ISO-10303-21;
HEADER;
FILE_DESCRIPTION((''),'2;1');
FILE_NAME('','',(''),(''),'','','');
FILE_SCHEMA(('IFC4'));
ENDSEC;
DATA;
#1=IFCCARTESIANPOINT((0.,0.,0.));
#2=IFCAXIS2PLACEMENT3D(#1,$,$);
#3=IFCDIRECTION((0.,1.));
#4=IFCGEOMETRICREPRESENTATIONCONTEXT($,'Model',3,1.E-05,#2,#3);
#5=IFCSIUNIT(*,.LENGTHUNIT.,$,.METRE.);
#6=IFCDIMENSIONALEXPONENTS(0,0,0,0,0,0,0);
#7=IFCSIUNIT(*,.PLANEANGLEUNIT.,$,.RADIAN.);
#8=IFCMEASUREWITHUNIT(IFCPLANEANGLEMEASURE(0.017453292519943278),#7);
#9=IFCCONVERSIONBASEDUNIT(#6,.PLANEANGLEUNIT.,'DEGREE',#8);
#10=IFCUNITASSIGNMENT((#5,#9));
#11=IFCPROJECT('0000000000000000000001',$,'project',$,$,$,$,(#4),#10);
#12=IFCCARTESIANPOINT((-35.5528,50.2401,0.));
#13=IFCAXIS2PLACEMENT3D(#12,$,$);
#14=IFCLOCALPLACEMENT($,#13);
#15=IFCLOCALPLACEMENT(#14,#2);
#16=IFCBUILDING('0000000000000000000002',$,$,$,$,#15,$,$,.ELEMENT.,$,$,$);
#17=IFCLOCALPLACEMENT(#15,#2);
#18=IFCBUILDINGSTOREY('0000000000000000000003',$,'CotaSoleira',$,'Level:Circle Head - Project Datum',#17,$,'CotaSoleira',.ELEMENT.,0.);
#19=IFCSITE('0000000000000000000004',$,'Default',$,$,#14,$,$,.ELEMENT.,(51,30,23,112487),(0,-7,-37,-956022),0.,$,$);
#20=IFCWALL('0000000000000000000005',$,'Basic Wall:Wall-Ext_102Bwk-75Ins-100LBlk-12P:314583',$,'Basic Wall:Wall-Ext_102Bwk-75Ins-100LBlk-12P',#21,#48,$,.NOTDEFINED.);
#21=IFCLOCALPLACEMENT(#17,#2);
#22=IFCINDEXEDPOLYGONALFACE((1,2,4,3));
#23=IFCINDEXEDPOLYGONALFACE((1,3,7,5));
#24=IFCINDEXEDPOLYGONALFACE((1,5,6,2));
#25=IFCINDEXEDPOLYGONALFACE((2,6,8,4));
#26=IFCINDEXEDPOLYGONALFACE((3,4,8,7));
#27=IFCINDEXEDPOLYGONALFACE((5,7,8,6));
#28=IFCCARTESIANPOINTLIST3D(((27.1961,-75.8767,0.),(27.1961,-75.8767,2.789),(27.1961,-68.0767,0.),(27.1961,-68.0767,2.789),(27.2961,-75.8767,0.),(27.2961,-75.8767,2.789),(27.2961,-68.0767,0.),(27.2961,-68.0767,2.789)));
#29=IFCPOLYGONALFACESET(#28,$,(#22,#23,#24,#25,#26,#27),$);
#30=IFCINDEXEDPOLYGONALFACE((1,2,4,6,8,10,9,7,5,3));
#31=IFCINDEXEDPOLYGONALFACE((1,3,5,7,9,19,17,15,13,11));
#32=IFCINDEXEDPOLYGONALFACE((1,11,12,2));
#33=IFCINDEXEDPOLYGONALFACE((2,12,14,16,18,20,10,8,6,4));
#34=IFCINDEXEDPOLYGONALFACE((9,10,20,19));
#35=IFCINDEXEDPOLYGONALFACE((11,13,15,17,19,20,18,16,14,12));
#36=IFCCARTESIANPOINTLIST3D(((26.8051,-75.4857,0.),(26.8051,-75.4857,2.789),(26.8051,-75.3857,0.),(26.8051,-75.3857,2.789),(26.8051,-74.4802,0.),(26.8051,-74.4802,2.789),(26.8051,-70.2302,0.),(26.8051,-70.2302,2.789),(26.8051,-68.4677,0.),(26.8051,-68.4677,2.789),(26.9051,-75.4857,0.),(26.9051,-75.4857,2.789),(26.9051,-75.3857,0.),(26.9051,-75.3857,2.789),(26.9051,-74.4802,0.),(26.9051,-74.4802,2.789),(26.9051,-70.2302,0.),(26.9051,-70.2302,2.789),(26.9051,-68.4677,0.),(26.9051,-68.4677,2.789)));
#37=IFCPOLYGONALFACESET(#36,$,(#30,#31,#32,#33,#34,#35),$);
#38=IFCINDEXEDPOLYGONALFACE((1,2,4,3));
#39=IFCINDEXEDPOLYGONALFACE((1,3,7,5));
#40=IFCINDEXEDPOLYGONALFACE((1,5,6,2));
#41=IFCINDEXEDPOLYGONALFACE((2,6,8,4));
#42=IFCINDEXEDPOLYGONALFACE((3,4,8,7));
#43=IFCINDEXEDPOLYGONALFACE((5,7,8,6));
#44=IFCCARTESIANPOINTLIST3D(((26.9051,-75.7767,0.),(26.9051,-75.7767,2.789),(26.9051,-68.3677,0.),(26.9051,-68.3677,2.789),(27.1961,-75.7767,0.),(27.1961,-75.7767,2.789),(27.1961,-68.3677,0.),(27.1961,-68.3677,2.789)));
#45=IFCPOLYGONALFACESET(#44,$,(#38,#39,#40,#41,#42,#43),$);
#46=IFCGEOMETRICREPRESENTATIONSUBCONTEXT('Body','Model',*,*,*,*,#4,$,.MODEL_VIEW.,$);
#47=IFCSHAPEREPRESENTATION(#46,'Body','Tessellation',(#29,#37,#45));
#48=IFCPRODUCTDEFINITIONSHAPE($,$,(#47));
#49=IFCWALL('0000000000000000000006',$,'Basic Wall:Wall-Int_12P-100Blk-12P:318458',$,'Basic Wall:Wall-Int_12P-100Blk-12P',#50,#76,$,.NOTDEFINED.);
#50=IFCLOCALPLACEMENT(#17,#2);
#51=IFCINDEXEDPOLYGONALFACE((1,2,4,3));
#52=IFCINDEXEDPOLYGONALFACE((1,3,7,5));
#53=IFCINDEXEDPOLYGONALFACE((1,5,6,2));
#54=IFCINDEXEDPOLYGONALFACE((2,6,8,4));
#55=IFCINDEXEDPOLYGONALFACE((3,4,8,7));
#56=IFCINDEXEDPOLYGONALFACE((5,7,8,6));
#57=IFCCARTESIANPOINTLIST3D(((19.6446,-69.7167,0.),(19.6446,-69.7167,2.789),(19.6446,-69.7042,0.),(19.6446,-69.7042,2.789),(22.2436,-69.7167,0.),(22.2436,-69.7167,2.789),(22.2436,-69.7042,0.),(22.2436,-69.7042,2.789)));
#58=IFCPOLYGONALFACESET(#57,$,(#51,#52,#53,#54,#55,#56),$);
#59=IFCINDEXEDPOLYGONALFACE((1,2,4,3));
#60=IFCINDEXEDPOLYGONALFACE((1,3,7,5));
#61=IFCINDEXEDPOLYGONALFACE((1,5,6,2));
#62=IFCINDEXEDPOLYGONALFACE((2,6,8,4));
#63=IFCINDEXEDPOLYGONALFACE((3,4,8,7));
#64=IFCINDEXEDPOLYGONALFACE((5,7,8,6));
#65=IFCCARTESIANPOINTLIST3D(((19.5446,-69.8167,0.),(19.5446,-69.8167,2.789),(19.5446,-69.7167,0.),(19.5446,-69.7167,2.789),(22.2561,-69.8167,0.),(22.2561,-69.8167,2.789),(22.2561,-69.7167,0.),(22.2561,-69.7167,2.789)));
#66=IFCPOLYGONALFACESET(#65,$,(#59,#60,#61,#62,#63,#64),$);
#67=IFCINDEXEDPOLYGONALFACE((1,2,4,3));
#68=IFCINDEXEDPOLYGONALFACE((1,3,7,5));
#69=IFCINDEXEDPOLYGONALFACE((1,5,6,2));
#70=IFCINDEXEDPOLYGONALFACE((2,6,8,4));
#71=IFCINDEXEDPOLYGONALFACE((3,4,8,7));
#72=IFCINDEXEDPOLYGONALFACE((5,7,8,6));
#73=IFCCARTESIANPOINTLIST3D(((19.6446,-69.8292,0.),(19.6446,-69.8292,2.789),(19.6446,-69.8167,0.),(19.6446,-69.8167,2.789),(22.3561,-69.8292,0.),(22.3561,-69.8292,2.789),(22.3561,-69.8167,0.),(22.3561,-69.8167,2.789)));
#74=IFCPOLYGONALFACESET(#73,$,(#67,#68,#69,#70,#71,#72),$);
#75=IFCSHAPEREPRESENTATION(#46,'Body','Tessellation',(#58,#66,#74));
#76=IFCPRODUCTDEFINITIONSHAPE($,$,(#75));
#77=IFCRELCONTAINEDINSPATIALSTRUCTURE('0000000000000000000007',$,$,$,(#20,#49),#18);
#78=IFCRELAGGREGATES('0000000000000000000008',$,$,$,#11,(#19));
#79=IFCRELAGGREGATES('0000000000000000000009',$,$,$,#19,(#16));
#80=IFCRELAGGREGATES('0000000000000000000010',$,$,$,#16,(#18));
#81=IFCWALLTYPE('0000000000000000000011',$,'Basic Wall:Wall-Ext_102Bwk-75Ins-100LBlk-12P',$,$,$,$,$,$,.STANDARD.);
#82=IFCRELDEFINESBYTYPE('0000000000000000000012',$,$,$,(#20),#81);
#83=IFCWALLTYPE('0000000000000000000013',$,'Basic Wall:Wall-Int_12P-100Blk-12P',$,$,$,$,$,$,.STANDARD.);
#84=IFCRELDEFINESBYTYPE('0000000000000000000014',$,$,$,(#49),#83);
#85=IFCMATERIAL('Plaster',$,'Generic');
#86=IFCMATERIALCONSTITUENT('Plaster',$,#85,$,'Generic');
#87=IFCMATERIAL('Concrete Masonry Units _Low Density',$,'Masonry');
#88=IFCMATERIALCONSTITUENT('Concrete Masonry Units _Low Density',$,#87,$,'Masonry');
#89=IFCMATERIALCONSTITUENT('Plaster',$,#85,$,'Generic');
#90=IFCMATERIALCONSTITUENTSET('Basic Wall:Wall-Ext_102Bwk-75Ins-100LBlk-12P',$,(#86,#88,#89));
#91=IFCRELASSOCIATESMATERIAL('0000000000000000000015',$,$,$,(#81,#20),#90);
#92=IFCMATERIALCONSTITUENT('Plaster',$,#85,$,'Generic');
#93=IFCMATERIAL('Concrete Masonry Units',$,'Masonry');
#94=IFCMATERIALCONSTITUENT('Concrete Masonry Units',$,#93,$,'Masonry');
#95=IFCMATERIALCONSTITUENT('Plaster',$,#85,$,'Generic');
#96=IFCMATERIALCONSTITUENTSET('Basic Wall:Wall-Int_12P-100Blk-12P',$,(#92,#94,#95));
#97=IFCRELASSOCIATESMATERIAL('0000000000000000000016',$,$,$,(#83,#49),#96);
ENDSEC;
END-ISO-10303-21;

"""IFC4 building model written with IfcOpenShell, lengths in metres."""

from ifc_helpers import new_model, entity, si_unit, converted_unit, direction, frame, origin, place, context, subcontext, project, spatial, indexed_curve, outline, extrude, material, constituent, constituent_set, type_object, element, save


model = new_model("IFC4")

# Units and contexts
model_context = context("Model", 3, precision=1e-05, world=origin(), true_north=direction((0.0, 1.0)))
body_context = subcontext(model_context, "Body", "Model", "MODEL_VIEW")
ifc_project = project(units=[si_unit("LENGTHUNIT", "METRE"), converted_unit("PLANEANGLEUNIT", "DEGREE", entity("IfcPlaneAngleMeasure", 0.017453292519943278), si_unit("PLANEANGLEUNIT", "RADIAN"), dimensions=[0, 0, 0, 0, 0, 0, 0])], contexts=[model_context])

# Site, building, storey
site_placement = place(None, frame((-35.5528, 50.2401, 0.0)))
site = spatial("IfcSite", under=ifc_project, at=site_placement, Name="Default", CompositionType="ELEMENT", RefLatitude=(51, 30, 23, 112487), RefLongitude=(0, -7, -37, -956022), RefElevation=0.0)
building_placement = place(site_placement, origin())
building = spatial("IfcBuilding", under=site, at=building_placement, CompositionType="ELEMENT")
storey_placement = place(building_placement, origin())
storey = spatial("IfcBuildingStorey", under=building, at=storey_placement, Name="CotaSoleira", ObjectType="Level:Circle Head - Project Datum", LongName="CotaSoleira", CompositionType="ELEMENT", Elevation=0.0)

# Wall
ifc_material_1 = material(Name="Plaster", Category="Generic")
ifc_constituent_1 = constituent(ifc_material_1, Name="Plaster", Category="Generic")
ifc_material_2 = material(Name="Concrete Masonry Units _Low Density", Category="Masonry")
ifc_constituent_2 = constituent(ifc_material_2, Name="Concrete Masonry Units _Low Density", Category="Masonry")
ifc_constituent_3 = constituent(ifc_material_1, Name="Plaster", Category="Generic")
ifc_constituent_set_1 = constituent_set(constituents=[ifc_constituent_1, ifc_constituent_2, ifc_constituent_3], Name="Basic Wall:Wall-Ext_102Bwk-75Ins-100LBlk-12P")
wall_type_1 = type_object("IfcWallType", Name="Basic Wall:Wall-Ext_102Bwk-75Ins-100LBlk-12P", PredefinedType="STANDARD", material=ifc_constituent_set_1)
wall_1_placement = place(storey_placement, frame((27.0506, -68.4677, 0.0), z_axis=(0.0, 0.0, 1.0), x_axis=(0.0, -1.0, 0.0)))
element("IfcWall", 1, at=wall_1_placement, inside=storey, type_object=wall_type_1, material=ifc_constituent_set_1, Name="Basic Wall:Wall-Ext_102Bwk-75Ins-100LBlk-12P:314583", ObjectType="Basic Wall:Wall-Ext_102Bwk-75Ins-100LBlk-12P", PredefinedType="NOTDEFINED", context=body_context, shape_type="SweptSolid", body=[
    extrude(outline(indexed_curve([(-1.3945, -3.9), (1.3945, -3.9), (1.3945, 3.9), (-1.3945, 3.9), (-1.3945, -3.9)], self_intersect=False)), frame((3.509, 0.1455, 1.3945), z_axis=(0.0, 1.0, 0.0), x_axis=(0.0, 0.0, 1.0)), (0.0, 0.0, 1.0), 0.1),
    extrude(outline(indexed_curve([(-1.3945, -4.3422), (1.3945, -4.3422), (1.3945, -2.5797), (1.3945, 1.6703), (1.3945, 2.5758), (1.3945, 2.6758), (-1.3945, 2.6758), (-1.3945, 2.5758), (-1.3945, 1.6703), (-1.3945, -2.5797), (-1.3945, -4.3422)], self_intersect=False)), frame((4.3422, -0.2455, 1.3945), z_axis=(0.0, 1.0, 0.0), x_axis=(0.0, 0.0, 1.0)), (0.0, 0.0, 1.0), 0.1),
    extrude(outline(indexed_curve([(-1.3945, -3.7045), (1.3945, -3.7045), (1.3945, 3.7045), (-1.3945, 3.7045), (-1.3945, -3.7045)], self_intersect=False)), frame((3.6045, -0.1455, 1.3945), z_axis=(0.0, 1.0, 0.0), x_axis=(0.0, 0.0, 1.0)), (0.0, 0.0, 1.0), 0.291),
])

# Shared definitions
ifc_constituent_4 = constituent(ifc_material_1, Name="Plaster", Category="Generic")
ifc_material_3 = material(Name="Concrete Masonry Units", Category="Masonry")
ifc_constituent_5 = constituent(ifc_material_3, Name="Concrete Masonry Units", Category="Masonry")
ifc_constituent_6 = constituent(ifc_material_1, Name="Plaster", Category="Generic")
ifc_constituent_set_2 = constituent_set(constituents=[ifc_constituent_4, ifc_constituent_5, ifc_constituent_6], Name="Basic Wall:Wall-Int_12P-100Blk-12P")
wall_type_2 = type_object("IfcWallType", Name="Basic Wall:Wall-Int_12P-100Blk-12P", PredefinedType="STANDARD", material=ifc_constituent_set_2)

# Wall
wall_2_placement = place(storey_placement, frame((22.2436, -69.7667, 0.0), z_axis=(0.0, 0.0, 1.0), x_axis=(-1.0, 0.0, 0.0)))
element("IfcWall", 2, at=wall_2_placement, inside=storey, type_object=wall_type_2, material=ifc_constituent_set_2, Name="Basic Wall:Wall-Int_12P-100Blk-12P:318458", ObjectType="Basic Wall:Wall-Int_12P-100Blk-12P", PredefinedType="NOTDEFINED", context=body_context, shape_type="SweptSolid", body=[
    extrude(outline(indexed_curve([(-0.0063, -1.2995), (0.0062, -1.2995), (0.0062, 1.2995), (-0.0063, 1.2995), (-0.0063, -1.2995)], self_intersect=False)), frame((1.2995, -0.0562, 0.0), z_axis=(0.0, 0.0, 1.0), x_axis=(0.0, 1.0, 0.0)), (0.0, 0.0, 1.0), 2.789),
    extrude(outline(indexed_curve([(-1.3557, -0.05), (1.3558, -0.05), (1.3558, 0.05), (-1.3557, 0.05), (-1.3557, -0.05)], self_intersect=False)), frame((1.3432, 0.0, 0.0)), (0.0, 0.0, 1.0), 2.789),
    extrude(outline(indexed_curve([(-0.0063, -1.3557), (0.0063, -1.3557), (0.0063, 1.3557), (-0.0062, 1.3557), (-0.0063, -1.3557)], self_intersect=False)), frame((1.2433, 0.0563, 0.0), z_axis=(0.0, 0.0, 1.0), x_axis=(0.0, -1.0, 0.0)), (0.0, 0.0, 1.0), 2.789),
])

save(model, "model.ifc")
